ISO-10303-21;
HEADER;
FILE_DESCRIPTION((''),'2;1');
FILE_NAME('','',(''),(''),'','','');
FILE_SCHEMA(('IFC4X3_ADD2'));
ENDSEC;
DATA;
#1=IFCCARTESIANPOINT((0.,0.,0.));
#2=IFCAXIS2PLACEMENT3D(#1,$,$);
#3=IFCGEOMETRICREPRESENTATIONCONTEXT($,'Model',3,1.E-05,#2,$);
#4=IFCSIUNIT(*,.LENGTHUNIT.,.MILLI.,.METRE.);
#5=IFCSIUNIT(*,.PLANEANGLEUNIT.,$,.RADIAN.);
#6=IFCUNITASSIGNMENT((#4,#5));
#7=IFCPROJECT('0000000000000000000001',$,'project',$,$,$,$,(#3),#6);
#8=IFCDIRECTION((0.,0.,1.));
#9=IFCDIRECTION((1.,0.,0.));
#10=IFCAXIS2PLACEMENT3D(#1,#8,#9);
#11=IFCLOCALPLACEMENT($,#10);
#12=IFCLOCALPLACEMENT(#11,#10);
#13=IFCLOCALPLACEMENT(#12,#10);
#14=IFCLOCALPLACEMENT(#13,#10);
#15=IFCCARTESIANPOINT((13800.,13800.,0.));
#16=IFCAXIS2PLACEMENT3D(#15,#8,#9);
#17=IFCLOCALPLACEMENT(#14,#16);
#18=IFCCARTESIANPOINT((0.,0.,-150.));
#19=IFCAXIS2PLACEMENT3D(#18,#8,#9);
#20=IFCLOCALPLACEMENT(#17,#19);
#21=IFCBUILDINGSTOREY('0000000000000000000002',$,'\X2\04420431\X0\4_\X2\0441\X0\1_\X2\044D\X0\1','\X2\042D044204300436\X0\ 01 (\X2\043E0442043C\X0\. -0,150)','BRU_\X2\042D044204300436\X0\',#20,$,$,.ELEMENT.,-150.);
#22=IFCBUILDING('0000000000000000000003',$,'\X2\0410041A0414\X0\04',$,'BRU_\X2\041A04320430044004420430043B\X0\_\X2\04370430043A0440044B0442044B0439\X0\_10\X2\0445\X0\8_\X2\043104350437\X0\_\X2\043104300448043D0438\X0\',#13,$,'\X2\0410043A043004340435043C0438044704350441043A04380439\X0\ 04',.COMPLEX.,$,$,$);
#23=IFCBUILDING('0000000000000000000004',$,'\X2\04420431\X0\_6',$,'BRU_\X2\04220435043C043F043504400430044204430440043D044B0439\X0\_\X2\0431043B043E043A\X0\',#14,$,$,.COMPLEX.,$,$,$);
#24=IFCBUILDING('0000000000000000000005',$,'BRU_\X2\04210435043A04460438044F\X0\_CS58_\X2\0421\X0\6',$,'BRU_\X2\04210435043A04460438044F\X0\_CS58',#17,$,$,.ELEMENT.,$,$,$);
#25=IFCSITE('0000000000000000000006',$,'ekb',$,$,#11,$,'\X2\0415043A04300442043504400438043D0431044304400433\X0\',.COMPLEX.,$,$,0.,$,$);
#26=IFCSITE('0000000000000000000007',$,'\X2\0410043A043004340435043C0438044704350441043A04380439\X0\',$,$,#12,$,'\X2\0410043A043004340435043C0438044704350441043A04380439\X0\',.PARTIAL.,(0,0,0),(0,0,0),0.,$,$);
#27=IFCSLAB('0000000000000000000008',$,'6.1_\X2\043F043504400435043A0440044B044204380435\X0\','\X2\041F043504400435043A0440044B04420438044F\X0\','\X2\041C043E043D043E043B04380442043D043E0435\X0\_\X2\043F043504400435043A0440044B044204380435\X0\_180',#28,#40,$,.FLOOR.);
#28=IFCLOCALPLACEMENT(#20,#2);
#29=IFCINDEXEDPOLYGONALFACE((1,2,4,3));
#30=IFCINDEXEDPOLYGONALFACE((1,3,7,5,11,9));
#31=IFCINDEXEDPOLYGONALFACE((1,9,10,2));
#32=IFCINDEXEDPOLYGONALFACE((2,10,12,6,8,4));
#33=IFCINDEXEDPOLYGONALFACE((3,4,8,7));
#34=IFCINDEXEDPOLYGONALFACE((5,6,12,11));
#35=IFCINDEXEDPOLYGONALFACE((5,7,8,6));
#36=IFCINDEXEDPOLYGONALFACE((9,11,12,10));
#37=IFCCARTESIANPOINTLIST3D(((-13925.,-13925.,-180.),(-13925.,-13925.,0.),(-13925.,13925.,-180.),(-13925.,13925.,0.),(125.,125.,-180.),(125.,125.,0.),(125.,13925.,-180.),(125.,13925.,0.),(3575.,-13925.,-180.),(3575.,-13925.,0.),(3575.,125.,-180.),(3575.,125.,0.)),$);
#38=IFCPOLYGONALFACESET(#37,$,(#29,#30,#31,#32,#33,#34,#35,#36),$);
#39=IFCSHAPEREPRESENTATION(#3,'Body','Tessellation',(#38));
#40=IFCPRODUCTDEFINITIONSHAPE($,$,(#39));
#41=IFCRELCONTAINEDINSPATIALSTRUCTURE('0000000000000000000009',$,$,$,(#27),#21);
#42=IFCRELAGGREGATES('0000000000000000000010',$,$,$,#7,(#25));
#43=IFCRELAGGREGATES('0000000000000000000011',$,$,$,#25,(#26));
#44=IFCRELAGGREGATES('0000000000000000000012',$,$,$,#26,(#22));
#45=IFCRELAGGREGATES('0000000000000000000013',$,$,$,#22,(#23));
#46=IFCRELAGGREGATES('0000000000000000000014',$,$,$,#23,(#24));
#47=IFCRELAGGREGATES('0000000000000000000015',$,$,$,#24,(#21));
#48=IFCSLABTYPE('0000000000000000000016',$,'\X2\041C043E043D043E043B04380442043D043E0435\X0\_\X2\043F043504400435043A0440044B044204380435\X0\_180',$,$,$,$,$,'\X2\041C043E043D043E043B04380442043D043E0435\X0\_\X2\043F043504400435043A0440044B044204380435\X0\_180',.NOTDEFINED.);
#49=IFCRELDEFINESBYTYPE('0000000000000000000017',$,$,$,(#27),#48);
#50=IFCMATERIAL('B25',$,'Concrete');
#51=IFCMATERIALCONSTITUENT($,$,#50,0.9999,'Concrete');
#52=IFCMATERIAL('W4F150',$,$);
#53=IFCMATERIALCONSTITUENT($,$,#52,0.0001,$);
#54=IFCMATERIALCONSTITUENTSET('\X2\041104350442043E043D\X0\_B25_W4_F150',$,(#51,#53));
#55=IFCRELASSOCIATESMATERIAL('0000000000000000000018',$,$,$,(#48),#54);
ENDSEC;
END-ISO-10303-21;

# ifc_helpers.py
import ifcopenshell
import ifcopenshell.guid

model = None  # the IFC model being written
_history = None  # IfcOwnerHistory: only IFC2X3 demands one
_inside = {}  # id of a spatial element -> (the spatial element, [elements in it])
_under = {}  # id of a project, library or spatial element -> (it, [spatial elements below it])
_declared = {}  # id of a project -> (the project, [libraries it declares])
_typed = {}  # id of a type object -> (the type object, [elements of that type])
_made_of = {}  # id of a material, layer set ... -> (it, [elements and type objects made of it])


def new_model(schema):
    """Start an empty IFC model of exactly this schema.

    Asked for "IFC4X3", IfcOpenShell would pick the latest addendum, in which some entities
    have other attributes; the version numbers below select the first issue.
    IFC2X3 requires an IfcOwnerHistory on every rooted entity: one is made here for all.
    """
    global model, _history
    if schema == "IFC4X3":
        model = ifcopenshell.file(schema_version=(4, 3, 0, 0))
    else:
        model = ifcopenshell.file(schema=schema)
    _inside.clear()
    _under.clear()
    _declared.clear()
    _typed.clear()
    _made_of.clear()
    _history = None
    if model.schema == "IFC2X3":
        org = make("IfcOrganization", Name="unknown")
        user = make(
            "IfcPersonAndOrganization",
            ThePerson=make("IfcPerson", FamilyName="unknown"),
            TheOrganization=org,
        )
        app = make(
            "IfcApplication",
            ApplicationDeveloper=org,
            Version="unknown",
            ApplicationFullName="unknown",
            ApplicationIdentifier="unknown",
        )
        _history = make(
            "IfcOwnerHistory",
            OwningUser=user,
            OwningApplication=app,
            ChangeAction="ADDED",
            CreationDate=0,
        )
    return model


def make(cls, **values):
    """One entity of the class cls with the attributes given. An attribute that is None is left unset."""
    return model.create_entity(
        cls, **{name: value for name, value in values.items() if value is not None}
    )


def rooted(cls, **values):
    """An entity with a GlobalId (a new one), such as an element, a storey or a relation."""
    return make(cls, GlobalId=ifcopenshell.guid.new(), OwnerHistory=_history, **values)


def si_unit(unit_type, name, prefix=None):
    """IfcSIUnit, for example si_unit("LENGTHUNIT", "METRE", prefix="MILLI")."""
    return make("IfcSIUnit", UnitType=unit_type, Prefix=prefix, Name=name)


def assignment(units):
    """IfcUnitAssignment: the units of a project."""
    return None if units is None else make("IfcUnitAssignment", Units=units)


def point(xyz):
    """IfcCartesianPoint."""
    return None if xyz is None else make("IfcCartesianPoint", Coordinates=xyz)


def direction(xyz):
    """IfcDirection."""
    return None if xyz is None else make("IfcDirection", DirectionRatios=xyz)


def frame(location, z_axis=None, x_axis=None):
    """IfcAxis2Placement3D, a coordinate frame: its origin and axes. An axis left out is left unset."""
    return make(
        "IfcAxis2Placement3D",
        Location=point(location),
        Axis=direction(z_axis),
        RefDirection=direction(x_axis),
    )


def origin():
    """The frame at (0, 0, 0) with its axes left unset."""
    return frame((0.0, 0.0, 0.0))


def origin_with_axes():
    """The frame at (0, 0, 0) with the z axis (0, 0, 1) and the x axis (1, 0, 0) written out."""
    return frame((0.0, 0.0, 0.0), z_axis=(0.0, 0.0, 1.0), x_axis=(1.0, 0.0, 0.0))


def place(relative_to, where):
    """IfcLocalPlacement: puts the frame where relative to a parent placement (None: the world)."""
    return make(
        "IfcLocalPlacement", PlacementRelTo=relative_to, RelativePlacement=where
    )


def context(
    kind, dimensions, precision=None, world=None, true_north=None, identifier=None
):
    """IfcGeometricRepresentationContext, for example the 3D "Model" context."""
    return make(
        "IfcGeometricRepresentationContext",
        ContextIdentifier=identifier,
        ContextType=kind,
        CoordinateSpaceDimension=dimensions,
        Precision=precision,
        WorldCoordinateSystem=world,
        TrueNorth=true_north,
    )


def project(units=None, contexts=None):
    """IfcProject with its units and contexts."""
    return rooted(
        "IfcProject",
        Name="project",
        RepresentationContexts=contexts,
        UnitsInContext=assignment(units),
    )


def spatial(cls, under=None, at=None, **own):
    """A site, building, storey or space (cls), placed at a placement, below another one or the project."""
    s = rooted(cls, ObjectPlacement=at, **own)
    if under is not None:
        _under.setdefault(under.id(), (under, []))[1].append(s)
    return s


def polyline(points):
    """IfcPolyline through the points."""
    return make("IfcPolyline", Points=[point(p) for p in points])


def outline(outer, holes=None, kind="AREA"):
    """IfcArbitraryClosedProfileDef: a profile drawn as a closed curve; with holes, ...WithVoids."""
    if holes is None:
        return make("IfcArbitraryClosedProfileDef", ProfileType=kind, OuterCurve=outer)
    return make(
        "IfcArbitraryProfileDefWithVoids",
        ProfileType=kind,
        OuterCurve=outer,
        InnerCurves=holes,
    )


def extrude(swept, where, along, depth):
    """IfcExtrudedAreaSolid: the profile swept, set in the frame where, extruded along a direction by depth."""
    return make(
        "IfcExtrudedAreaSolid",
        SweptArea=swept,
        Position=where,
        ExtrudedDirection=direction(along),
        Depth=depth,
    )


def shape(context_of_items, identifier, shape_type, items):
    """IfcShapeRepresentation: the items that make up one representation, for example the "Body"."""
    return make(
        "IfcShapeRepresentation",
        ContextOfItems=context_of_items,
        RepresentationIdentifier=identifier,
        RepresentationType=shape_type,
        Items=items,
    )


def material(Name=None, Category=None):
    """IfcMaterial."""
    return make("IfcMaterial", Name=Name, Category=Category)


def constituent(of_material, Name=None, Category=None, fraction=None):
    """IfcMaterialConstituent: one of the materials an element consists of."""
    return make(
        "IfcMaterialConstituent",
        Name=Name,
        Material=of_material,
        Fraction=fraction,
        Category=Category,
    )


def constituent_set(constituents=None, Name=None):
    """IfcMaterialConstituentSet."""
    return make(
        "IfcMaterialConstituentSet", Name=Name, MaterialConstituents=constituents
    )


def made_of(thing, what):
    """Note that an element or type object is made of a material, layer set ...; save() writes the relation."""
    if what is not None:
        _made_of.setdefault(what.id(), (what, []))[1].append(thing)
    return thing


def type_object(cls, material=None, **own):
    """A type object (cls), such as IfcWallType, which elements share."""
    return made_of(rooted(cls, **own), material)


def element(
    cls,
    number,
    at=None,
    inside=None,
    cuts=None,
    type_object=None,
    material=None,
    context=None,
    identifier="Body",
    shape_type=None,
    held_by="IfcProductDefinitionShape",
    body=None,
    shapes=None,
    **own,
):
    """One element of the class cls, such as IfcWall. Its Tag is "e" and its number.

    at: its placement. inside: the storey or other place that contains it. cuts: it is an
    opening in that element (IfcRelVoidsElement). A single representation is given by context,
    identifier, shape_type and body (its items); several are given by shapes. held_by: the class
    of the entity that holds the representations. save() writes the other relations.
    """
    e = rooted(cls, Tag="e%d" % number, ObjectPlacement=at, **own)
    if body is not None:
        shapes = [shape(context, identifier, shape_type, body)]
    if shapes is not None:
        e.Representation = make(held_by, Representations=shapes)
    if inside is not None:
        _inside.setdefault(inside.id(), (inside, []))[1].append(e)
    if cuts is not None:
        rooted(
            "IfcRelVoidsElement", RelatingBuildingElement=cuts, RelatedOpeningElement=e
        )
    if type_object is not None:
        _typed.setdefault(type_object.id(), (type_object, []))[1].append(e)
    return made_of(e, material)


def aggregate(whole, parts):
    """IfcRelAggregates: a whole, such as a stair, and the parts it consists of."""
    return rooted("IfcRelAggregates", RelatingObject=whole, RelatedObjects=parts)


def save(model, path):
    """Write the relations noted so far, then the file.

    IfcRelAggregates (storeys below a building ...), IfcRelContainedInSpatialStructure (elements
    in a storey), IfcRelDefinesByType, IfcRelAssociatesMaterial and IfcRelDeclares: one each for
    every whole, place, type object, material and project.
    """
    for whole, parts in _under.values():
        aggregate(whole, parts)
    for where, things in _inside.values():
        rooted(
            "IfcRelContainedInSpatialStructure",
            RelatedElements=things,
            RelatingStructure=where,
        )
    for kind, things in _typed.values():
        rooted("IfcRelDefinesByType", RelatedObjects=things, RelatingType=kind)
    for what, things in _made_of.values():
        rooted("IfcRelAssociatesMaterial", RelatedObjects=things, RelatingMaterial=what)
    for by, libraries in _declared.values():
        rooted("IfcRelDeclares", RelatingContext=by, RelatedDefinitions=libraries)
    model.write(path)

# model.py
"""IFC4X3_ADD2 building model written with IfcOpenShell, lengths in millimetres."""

from ifc_helpers import new_model, si_unit, frame, origin, origin_with_axes, place, context, project, spatial, polyline, outline, extrude, material, constituent, constituent_set, type_object, element, save


model = new_model("IFC4X3_ADD2")

# Units and contexts
model_context = context("Model", 3, precision=1e-05, world=origin())
ifc_project = project(units=[si_unit("LENGTHUNIT", "METRE", prefix="MILLI"), si_unit("PLANEANGLEUNIT", "RADIAN")], contexts=[model_context])

# Sites, buildings, storey
site_1_placement = place(None, origin_with_axes())
site_1 = spatial("IfcSite", under=ifc_project, at=site_1_placement, Name="ekb", LongName="Екатеринбург", CompositionType="COMPLEX", RefElevation=0.0)
site_2_placement = place(site_1_placement, origin_with_axes())
site_2 = spatial("IfcSite", under=site_1, at=site_2_placement, Name="Академический", LongName="Академический", CompositionType="PARTIAL", RefLatitude=(0, 0, 0), RefLongitude=(0, 0, 0), RefElevation=0.0)
building_1_placement = place(site_2_placement, origin_with_axes())
building_1 = spatial("IfcBuilding", under=site_2, at=building_1_placement, Name="АКД04", ObjectType="BRU_Квартал_закрытый_10х8_без_башни", LongName="Академический 04", CompositionType="COMPLEX")
building_2_placement = place(building_1_placement, origin_with_axes())
building_2 = spatial("IfcBuilding", under=building_1, at=building_2_placement, Name="тб_6", ObjectType="BRU_Температурный_блок", CompositionType="COMPLEX")
building_3_placement = place(building_2_placement, frame((13800.0, 13800.0, 0.0), z_axis=(0.0, 0.0, 1.0), x_axis=(1.0, 0.0, 0.0)))
building_3 = spatial("IfcBuilding", under=building_2, at=building_3_placement, Name="BRU_Секция_CS58_С6", ObjectType="BRU_Секция_CS58", CompositionType="ELEMENT")
storey_placement = place(building_3_placement, frame((0.0, 0.0, -150.0), z_axis=(0.0, 0.0, 1.0), x_axis=(1.0, 0.0, 0.0)))
storey = spatial("IfcBuildingStorey", under=building_3, at=storey_placement, Name="тб4_с1_э1", Description="Этаж 01 (отм. -0,150)", ObjectType="BRU_Этаж", CompositionType="ELEMENT", Elevation=-150.0)

# Shared definitions
ifc_material_1 = material(Name="B25", Category="Concrete")
ifc_material_2 = material(Name="W4F150")

# Slab
ifc_constituent_1 = constituent(ifc_material_1, Category="Concrete", fraction=0.9999)
ifc_constituent_2 = constituent(ifc_material_2, fraction=0.0001)
ifc_constituent_set_1 = constituent_set(constituents=[ifc_constituent_1, ifc_constituent_2], Name="Бетон_B25_W4_F150")
slab_type = type_object("IfcSlabType", Name="Монолитное_перекрытие_180", ElementType="Монолитное_перекрытие_180", PredefinedType="NOTDEFINED", material=ifc_constituent_set_1)
slab_1_placement = place(storey_placement, frame((0.0, 0.0, -180.0), z_axis=(0.0, 0.0, 1.0), x_axis=(1.0, 0.0, 0.0)))
element("IfcSlab", 1, at=slab_1_placement, inside=storey, type_object=slab_type, Name="6.1_перекрытие", Description="Перекрытия", ObjectType="Монолитное_перекрытие_180", PredefinedType="FLOOR", context=model_context, shape_type="SweptSolid", body=[
    extrude(outline(polyline([(-13925.0, -13925.0), (3575.0, -13925.0), (3575.0, 125.0), (125.0, 125.0), (125.0, 13925.0), (-13925.0, 13925.0), (-13925.0, -13925.0)])), origin_with_axes(), (0.0, 0.0, 1.0), 180.0),
])

save(model, "model.ifc")
